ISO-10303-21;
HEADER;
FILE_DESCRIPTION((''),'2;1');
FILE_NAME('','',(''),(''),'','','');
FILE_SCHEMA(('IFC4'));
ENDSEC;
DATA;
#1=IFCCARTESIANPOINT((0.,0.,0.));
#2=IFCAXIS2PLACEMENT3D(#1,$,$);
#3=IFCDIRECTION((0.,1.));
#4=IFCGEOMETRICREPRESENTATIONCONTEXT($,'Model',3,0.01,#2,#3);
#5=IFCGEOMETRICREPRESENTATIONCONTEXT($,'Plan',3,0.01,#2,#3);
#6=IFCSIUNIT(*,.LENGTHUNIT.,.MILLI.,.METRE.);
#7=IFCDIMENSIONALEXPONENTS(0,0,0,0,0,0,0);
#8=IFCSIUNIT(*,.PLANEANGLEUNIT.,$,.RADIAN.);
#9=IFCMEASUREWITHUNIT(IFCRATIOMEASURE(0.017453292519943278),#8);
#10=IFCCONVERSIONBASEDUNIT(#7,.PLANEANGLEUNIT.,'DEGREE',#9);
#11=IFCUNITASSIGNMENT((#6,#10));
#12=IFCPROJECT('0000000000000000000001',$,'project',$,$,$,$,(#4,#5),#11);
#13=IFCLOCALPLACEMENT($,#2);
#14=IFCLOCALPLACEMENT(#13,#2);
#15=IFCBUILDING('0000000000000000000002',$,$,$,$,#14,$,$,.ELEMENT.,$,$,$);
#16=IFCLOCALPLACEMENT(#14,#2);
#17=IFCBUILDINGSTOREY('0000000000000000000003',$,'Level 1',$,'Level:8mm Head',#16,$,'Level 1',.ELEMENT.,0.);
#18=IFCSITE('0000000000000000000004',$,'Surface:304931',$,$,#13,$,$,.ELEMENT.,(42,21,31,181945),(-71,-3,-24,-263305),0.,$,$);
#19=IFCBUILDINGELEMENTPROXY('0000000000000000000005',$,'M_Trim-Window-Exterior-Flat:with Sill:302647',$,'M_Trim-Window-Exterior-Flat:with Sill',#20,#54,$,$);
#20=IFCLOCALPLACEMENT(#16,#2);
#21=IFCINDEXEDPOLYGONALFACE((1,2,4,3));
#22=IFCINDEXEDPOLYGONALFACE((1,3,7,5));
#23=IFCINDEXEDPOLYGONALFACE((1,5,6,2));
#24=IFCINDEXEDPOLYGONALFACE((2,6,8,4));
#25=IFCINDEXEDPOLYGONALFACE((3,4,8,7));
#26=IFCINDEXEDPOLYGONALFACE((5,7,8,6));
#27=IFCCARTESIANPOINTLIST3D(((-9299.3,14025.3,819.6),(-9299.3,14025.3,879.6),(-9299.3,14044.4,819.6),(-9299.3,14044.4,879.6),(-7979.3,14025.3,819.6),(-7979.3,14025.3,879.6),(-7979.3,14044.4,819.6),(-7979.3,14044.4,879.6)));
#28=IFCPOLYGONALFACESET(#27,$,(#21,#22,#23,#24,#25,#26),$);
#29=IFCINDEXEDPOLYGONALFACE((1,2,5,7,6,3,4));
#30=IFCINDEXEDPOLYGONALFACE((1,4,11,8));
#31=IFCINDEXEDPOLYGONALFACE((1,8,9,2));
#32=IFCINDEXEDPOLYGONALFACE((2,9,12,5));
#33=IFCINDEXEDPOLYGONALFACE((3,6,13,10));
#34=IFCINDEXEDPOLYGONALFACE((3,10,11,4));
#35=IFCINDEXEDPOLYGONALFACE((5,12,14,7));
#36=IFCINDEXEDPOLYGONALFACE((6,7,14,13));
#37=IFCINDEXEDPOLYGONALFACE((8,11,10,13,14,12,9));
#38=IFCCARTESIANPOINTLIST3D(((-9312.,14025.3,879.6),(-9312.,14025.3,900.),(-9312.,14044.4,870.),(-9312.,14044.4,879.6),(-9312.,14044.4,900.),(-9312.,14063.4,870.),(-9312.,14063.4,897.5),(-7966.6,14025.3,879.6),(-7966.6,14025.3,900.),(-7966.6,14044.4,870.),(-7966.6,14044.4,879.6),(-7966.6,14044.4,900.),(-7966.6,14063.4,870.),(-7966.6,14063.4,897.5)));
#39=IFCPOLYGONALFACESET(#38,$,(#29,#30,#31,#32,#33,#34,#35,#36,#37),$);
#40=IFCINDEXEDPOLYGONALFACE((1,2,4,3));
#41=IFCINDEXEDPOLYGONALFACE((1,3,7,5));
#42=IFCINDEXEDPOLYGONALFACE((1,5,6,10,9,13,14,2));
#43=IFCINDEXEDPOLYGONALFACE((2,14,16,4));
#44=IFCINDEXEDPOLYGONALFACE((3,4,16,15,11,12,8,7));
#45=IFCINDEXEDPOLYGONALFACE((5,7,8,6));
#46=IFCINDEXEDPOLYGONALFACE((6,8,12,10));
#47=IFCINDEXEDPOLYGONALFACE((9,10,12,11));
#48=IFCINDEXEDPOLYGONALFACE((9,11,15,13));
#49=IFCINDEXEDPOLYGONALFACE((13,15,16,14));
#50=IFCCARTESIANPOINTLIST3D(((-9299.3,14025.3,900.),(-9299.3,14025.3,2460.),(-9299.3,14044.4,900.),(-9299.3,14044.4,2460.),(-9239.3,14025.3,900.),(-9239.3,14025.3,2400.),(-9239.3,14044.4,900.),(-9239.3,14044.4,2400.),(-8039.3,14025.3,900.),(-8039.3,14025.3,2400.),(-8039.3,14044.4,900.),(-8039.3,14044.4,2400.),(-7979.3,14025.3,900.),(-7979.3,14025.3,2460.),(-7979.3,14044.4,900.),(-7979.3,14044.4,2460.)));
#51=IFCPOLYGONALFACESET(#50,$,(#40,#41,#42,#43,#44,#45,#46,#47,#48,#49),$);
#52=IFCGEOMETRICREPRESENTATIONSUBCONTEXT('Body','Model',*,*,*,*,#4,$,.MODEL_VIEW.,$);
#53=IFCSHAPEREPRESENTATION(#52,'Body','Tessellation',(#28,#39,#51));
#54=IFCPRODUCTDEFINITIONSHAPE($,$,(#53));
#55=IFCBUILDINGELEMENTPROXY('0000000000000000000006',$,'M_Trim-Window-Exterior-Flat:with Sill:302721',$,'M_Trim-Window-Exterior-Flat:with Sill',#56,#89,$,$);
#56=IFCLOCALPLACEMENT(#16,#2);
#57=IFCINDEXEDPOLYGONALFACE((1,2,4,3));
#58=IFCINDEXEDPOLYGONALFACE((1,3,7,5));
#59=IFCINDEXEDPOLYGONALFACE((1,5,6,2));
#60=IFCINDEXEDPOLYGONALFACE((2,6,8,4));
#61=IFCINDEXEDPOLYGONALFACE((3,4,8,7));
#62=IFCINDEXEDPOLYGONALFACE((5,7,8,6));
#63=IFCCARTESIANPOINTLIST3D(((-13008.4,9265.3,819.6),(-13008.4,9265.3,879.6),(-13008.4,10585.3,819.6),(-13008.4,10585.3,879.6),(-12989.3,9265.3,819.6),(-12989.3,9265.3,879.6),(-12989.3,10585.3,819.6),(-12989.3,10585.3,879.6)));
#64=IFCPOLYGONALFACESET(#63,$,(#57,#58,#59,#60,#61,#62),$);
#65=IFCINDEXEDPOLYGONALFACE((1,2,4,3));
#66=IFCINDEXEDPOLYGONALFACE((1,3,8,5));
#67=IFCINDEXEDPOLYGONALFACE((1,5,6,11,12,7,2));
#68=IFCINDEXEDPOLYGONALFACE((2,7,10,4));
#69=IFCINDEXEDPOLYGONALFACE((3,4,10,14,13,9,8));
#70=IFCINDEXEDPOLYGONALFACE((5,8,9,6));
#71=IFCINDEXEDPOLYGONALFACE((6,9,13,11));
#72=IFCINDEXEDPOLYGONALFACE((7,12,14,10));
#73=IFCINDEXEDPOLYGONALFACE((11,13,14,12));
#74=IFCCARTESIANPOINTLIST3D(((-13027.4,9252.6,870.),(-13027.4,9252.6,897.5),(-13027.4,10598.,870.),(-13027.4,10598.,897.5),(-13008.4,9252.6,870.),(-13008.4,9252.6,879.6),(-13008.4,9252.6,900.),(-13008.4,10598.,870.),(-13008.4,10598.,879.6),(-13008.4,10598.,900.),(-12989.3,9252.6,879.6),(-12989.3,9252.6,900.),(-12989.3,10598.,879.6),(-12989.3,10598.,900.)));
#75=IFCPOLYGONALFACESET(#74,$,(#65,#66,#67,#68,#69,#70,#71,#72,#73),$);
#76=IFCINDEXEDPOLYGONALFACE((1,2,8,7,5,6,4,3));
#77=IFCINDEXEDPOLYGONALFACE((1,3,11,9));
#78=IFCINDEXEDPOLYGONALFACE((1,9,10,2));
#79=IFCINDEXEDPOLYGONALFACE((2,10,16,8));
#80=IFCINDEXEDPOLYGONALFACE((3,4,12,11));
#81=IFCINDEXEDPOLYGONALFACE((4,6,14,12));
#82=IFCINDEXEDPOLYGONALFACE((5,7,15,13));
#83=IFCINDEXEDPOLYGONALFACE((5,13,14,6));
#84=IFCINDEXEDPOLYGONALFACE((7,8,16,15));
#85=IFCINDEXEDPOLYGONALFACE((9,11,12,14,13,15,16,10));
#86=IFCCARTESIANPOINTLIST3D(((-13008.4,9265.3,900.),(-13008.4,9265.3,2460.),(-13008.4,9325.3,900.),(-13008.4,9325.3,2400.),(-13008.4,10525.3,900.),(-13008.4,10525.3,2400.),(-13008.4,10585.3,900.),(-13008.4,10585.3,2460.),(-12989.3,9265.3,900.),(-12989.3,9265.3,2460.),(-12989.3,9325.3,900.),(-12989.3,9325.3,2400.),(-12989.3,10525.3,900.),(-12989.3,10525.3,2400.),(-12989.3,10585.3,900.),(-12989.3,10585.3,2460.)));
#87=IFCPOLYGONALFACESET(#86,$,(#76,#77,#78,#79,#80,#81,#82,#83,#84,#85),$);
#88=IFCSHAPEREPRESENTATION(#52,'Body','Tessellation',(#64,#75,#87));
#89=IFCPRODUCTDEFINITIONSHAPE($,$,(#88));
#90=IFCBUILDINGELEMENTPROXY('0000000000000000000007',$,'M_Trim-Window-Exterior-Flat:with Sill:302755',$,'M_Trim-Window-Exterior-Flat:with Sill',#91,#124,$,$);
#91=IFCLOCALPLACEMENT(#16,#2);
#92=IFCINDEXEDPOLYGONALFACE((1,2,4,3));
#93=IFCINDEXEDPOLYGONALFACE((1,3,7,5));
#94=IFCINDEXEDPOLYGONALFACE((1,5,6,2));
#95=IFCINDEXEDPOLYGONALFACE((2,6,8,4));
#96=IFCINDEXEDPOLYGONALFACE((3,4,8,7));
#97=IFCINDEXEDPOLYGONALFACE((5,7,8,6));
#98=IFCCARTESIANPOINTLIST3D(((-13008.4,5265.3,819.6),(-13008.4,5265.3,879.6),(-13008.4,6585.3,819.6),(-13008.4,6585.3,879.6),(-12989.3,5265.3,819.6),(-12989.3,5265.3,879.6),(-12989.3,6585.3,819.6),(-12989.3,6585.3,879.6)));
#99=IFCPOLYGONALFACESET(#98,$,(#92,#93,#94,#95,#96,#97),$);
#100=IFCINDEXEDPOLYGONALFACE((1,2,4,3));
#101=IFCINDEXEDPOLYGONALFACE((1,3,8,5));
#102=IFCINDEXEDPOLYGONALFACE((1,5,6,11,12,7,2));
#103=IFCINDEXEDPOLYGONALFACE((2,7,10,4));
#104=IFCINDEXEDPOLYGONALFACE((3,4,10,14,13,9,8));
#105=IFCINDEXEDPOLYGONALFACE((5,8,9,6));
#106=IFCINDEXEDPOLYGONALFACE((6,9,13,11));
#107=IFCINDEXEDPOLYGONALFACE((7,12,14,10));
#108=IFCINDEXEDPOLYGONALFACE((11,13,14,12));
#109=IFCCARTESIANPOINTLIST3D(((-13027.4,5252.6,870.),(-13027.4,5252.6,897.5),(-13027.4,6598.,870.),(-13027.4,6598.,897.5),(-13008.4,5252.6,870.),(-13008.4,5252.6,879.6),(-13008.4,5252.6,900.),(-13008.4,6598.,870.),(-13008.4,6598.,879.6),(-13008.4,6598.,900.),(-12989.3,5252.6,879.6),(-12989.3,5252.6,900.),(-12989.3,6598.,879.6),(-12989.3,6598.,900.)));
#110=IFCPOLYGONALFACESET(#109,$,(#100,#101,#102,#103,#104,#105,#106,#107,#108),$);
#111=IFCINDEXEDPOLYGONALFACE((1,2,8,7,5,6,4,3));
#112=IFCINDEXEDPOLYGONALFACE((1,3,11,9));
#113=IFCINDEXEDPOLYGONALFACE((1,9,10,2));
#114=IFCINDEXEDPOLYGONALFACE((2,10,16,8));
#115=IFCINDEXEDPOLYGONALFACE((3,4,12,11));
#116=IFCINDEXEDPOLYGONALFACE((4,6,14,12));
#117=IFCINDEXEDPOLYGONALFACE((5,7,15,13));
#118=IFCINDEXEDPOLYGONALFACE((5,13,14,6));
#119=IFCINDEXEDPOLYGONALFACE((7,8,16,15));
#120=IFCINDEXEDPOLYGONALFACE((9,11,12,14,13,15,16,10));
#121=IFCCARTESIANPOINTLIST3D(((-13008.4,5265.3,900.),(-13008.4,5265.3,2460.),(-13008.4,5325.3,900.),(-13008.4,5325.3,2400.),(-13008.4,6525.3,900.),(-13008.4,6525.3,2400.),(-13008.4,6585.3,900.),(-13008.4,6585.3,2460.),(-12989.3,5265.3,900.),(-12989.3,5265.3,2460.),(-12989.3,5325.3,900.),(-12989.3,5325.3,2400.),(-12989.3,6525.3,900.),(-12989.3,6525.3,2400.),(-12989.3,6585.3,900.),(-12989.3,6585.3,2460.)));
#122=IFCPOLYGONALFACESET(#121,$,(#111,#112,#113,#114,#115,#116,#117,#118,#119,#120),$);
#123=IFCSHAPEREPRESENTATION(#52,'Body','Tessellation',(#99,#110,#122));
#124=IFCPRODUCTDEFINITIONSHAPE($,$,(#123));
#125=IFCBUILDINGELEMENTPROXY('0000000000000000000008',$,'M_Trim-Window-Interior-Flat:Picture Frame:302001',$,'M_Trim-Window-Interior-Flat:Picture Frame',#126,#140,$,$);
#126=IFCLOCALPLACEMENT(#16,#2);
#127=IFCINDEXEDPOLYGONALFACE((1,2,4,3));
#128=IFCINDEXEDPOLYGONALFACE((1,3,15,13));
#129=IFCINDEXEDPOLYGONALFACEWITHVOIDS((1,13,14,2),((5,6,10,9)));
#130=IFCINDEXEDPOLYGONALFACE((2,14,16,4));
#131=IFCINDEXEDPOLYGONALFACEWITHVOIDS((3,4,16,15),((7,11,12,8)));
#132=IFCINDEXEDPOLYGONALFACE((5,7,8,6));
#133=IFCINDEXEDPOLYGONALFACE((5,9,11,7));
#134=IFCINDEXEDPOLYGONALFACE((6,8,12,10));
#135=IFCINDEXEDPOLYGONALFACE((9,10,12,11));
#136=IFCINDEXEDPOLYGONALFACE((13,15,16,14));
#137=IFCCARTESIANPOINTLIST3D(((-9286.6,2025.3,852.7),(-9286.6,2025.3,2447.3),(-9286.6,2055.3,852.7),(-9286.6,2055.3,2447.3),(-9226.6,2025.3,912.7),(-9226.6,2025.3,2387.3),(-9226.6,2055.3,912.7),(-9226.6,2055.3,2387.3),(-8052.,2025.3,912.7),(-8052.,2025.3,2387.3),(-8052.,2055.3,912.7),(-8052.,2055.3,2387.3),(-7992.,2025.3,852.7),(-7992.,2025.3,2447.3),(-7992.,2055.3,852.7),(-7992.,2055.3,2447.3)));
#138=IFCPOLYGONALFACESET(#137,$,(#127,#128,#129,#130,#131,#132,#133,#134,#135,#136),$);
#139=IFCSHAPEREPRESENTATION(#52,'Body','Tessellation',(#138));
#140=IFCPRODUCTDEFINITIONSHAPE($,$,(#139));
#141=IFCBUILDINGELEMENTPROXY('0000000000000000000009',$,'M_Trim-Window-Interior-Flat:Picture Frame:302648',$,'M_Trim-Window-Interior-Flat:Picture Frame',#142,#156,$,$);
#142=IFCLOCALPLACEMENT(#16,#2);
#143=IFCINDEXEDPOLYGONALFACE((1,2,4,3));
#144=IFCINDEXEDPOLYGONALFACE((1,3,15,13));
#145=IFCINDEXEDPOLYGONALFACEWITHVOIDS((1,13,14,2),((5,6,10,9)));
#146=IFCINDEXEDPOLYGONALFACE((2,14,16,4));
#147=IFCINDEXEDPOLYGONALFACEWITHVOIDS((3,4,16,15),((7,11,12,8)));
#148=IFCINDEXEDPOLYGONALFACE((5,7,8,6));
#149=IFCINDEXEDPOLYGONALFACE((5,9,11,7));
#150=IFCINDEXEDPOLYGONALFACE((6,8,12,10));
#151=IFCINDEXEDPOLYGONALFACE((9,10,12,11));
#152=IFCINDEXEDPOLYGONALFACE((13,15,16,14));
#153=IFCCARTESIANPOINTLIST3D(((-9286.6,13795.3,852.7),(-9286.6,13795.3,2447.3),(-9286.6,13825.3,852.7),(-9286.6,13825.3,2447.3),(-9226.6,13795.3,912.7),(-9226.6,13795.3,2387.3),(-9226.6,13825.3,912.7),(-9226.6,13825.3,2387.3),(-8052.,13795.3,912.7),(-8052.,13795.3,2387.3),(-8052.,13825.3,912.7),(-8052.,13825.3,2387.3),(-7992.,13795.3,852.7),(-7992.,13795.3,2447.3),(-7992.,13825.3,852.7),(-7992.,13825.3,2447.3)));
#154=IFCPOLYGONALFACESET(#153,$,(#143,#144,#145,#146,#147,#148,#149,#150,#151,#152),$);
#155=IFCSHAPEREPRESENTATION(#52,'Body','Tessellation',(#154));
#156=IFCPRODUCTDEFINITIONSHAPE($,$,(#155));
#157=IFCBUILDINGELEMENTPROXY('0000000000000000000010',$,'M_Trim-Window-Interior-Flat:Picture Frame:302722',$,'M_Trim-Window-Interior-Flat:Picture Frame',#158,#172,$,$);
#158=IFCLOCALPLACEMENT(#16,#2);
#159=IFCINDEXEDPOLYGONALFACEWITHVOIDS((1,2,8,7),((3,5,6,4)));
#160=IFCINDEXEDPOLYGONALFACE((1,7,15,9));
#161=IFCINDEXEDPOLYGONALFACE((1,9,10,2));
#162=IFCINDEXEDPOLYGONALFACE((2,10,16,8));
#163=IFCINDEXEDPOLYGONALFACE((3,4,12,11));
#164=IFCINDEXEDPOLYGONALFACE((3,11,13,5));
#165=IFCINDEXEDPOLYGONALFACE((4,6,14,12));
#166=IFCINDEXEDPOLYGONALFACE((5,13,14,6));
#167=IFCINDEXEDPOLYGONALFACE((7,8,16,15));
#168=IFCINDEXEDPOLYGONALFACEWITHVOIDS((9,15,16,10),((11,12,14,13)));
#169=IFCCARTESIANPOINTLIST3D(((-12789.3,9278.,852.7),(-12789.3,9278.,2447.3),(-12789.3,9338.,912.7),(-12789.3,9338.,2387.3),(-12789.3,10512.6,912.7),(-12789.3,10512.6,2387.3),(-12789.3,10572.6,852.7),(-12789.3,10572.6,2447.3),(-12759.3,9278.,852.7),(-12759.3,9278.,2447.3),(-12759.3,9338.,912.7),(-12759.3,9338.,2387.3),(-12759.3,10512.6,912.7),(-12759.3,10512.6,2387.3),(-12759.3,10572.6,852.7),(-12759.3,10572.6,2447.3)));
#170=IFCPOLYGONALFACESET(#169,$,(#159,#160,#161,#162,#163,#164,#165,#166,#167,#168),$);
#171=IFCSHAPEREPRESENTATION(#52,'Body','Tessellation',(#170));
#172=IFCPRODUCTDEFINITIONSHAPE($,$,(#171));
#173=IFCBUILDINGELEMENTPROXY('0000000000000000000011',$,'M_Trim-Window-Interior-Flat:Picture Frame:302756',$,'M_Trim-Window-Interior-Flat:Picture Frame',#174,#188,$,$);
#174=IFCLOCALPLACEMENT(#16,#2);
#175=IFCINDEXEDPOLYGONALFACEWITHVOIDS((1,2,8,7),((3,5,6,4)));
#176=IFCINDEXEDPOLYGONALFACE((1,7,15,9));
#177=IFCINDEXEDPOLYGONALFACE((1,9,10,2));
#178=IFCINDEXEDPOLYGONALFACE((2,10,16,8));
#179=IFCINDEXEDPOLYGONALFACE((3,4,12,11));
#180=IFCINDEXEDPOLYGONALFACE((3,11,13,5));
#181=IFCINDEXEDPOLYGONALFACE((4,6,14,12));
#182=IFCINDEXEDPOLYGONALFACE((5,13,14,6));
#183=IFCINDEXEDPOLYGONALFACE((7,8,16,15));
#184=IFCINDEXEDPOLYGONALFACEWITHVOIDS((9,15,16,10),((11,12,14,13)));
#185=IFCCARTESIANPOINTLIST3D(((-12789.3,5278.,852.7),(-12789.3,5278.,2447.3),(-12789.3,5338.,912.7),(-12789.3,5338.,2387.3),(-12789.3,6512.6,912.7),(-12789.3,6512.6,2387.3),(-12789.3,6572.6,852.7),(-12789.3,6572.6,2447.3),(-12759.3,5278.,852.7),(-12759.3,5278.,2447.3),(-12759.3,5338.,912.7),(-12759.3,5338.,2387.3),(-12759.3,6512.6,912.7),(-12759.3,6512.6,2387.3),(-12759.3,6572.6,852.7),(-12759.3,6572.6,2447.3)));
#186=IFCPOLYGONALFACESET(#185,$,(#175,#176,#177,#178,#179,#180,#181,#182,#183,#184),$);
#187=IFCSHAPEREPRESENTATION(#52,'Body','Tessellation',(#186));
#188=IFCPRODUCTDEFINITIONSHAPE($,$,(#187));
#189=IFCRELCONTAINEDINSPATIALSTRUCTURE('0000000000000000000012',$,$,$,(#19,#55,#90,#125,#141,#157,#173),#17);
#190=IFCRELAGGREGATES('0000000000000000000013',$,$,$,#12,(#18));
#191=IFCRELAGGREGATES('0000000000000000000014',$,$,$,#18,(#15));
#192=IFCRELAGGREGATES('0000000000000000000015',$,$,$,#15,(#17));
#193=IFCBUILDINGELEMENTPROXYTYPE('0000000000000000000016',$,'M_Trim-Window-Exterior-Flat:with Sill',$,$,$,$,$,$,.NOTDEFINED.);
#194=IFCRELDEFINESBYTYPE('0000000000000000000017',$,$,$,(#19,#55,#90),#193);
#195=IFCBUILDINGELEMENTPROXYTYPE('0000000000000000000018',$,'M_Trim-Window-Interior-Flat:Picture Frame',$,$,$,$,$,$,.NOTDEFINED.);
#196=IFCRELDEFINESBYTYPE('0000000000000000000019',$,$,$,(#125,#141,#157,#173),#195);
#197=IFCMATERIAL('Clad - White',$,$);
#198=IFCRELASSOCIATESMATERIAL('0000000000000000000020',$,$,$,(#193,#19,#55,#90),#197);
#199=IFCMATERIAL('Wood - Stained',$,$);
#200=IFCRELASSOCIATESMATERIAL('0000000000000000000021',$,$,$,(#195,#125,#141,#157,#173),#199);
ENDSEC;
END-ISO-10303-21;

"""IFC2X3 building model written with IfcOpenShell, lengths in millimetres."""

from ifc_helpers import new_model, entity, si_unit, converted_unit, direction, frame, frame_2d, origin, place, context, subcontext, project, spatial, polyline, rectangle, outline, extrude, source, transform, mapped, material, type_object, type_shapes, element, save


model = new_model("IFC2X3")

# Units and contexts
model_context = context("Model", 3, precision=0.01, world=origin(), true_north=direction((0.0, 1.0)))
plan_context = context("Plan", 3, precision=0.01, world=origin(), true_north=direction((0.0, 1.0)))
body_context = subcontext(model_context, "Body", "Model", "MODEL_VIEW")
ifc_project = project(units=[si_unit("LENGTHUNIT", "METRE", prefix="MILLI"), converted_unit("PLANEANGLEUNIT", "DEGREE", entity("IfcRatioMeasure", 0.017453292519943278), si_unit("PLANEANGLEUNIT", "RADIAN"), dimensions=[0, 0, 0, 0, 0, 0, 0])], contexts=[model_context, plan_context])

# Site, building, storey
site_placement = place(None, origin())
site = spatial("IfcSite", under=ifc_project, at=site_placement, Name="Surface:304931", CompositionType="ELEMENT", RefLatitude=(42, 21, 31, 181945), RefLongitude=(-71, -3, -24, -263305), RefElevation=0.0)
building_placement = place(site_placement, origin())
building = spatial("IfcBuilding", under=site, at=building_placement, CompositionType="ELEMENT")
storey_placement = place(building_placement, origin())
storey = spatial("IfcBuildingStorey", under=building, at=storey_placement, Name="Level 1", ObjectType="Level:8mm Head", LongName="Level 1", CompositionType="ELEMENT", Elevation=0.0)

# Building element proxies
ifc_material_1 = material(Name="Clad - White")
ifc_material_2 = material(Name="Wood - Stained")
building_element_proxy_type_1 = type_object("IfcBuildingElementProxyType", Name="M_Trim-Window-Exterior-Flat:with Sill", PredefinedType="NOTDEFINED", material=ifc_material_1)
shared_shape_1 = source(origin(), body_context, "Body", "SweptSolid", [
    extrude(rectangle(XDim=1320.0, YDim=60.0, at=frame_2d((0.0, 0.0), x_axis=(1.0, 0.0))), frame((0.0, -1550.4, 0.0), z_axis=(0.0, 0.0, 1.0), x_axis=(-1.0, 0.0, 0.0)), (0.0, 0.0, 1.0), 19.0),
    extrude(outline(polyline([(-19.0, -15.2), (0.0, -15.2), (0.0, -5.7), (19.0, -5.7), (19.0, 14.8), (0.0, 14.8), (-19.0, 12.3), (-19.0, -15.2)])), frame((-672.7, -1514.8, 19.0), z_axis=(1.0, 0.0, 0.0), x_axis=(0.0, 0.0, -1.0)), (0.0, 0.0, 1.0), 1345.4),
    extrude(outline(polyline([(-795.0, -660.0), (765.0, -660.0), (765.0, -600.0), (-735.0, -600.0), (-735.0, 600.0), (765.0, 600.0), (765.0, 660.0), (-795.0, 660.0), (-795.0, -660.0)])), frame((0.0, -735.0, 0.0), z_axis=(0.0, 0.0, 1.0), x_axis=(0.0, -1.0, 0.0)), (0.0, 0.0, 1.0), 19.0),
])
type_shapes(building_element_proxy_type_1, [shared_shape_1])
for number, where, z_axis, x_axis, name in (
    (1, (-8639.3, 14025.3, 2400.0), (0.0, 1.0, 0.0), (-1.0, 0.0, 0.0), "M_Trim-Window-Exterior-Flat:with Sill:302647"),
    (2, (-12989.3, 9925.3, 2400.0), (-1.0, 0.0, 0.0), (0.0, -1.0, 0.0), "M_Trim-Window-Exterior-Flat:with Sill:302721"),
    (3, (-12989.3, 5925.3, 2400.0), (-1.0, 0.0, 0.0), (0.0, -1.0, 0.0), "M_Trim-Window-Exterior-Flat:with Sill:302755"),
):
    element("IfcBuildingElementProxy", number, at=place(storey_placement, frame(where, z_axis=z_axis, x_axis=x_axis)), inside=storey, type_object=building_element_proxy_type_1, material=ifc_material_1, Name=name, ObjectType="M_Trim-Window-Exterior-Flat:with Sill", context=body_context, shape_type="MappedRepresentation", body=[
        mapped(shared_shape_1, transform((0.0, 0.0, 0.0), scale=1.0)),
    ])
building_element_proxy_type_2 = type_object("IfcBuildingElementProxyType", Name="M_Trim-Window-Interior-Flat:Picture Frame", PredefinedType="NOTDEFINED", material=ifc_material_2)
shared_shape_2 = source(origin(), body_context, "Body", "SweptSolid", [
    extrude(outline(polyline([(-647.3, -797.3), (647.3, -797.3), (647.3, 797.3), (-647.3, 797.3), (-647.3, -797.3)]), holes=[polyline([(-587.3, -737.3), (-587.3, 737.3), (587.3, 737.3), (587.3, -737.3), (-587.3, -737.3)])]), frame((0.0, -750.0, 0.0), z_axis=(0.0, 0.0, 1.0), x_axis=(-1.0, 0.0, 0.0)), (0.0, 0.0, 1.0), 30.0),
])
type_shapes(building_element_proxy_type_2, [shared_shape_2])
for number, where, z_axis, x_axis, name in (
    (4, (-8639.3, 2025.3, 2400.0), (0.0, 1.0, 0.0), (-1.0, 0.0, 0.0), "M_Trim-Window-Interior-Flat:Picture Frame:302001"),
    (5, (-8639.3, 13825.3, 2400.0), (0.0, -1.0, 0.0), (1.0, 0.0, 0.0), "M_Trim-Window-Interior-Flat:Picture Frame:302648"),
    (6, (-12789.3, 9925.3, 2400.0), (1.0, 0.0, 0.0), (0.0, 1.0, 0.0), "M_Trim-Window-Interior-Flat:Picture Frame:302722"),
    (7, (-12789.3, 5925.3, 2400.0), (1.0, 0.0, 0.0), (0.0, 1.0, 0.0), "M_Trim-Window-Interior-Flat:Picture Frame:302756"),
):
    element("IfcBuildingElementProxy", number, at=place(storey_placement, frame(where, z_axis=z_axis, x_axis=x_axis)), inside=storey, type_object=building_element_proxy_type_2, material=ifc_material_2, Name=name, ObjectType="M_Trim-Window-Interior-Flat:Picture Frame", context=body_context, shape_type="MappedRepresentation", body=[
        mapped(shared_shape_2, transform((0.0, 0.0, 0.0), scale=1.0)),
    ])

save(model, "model.ifc")
